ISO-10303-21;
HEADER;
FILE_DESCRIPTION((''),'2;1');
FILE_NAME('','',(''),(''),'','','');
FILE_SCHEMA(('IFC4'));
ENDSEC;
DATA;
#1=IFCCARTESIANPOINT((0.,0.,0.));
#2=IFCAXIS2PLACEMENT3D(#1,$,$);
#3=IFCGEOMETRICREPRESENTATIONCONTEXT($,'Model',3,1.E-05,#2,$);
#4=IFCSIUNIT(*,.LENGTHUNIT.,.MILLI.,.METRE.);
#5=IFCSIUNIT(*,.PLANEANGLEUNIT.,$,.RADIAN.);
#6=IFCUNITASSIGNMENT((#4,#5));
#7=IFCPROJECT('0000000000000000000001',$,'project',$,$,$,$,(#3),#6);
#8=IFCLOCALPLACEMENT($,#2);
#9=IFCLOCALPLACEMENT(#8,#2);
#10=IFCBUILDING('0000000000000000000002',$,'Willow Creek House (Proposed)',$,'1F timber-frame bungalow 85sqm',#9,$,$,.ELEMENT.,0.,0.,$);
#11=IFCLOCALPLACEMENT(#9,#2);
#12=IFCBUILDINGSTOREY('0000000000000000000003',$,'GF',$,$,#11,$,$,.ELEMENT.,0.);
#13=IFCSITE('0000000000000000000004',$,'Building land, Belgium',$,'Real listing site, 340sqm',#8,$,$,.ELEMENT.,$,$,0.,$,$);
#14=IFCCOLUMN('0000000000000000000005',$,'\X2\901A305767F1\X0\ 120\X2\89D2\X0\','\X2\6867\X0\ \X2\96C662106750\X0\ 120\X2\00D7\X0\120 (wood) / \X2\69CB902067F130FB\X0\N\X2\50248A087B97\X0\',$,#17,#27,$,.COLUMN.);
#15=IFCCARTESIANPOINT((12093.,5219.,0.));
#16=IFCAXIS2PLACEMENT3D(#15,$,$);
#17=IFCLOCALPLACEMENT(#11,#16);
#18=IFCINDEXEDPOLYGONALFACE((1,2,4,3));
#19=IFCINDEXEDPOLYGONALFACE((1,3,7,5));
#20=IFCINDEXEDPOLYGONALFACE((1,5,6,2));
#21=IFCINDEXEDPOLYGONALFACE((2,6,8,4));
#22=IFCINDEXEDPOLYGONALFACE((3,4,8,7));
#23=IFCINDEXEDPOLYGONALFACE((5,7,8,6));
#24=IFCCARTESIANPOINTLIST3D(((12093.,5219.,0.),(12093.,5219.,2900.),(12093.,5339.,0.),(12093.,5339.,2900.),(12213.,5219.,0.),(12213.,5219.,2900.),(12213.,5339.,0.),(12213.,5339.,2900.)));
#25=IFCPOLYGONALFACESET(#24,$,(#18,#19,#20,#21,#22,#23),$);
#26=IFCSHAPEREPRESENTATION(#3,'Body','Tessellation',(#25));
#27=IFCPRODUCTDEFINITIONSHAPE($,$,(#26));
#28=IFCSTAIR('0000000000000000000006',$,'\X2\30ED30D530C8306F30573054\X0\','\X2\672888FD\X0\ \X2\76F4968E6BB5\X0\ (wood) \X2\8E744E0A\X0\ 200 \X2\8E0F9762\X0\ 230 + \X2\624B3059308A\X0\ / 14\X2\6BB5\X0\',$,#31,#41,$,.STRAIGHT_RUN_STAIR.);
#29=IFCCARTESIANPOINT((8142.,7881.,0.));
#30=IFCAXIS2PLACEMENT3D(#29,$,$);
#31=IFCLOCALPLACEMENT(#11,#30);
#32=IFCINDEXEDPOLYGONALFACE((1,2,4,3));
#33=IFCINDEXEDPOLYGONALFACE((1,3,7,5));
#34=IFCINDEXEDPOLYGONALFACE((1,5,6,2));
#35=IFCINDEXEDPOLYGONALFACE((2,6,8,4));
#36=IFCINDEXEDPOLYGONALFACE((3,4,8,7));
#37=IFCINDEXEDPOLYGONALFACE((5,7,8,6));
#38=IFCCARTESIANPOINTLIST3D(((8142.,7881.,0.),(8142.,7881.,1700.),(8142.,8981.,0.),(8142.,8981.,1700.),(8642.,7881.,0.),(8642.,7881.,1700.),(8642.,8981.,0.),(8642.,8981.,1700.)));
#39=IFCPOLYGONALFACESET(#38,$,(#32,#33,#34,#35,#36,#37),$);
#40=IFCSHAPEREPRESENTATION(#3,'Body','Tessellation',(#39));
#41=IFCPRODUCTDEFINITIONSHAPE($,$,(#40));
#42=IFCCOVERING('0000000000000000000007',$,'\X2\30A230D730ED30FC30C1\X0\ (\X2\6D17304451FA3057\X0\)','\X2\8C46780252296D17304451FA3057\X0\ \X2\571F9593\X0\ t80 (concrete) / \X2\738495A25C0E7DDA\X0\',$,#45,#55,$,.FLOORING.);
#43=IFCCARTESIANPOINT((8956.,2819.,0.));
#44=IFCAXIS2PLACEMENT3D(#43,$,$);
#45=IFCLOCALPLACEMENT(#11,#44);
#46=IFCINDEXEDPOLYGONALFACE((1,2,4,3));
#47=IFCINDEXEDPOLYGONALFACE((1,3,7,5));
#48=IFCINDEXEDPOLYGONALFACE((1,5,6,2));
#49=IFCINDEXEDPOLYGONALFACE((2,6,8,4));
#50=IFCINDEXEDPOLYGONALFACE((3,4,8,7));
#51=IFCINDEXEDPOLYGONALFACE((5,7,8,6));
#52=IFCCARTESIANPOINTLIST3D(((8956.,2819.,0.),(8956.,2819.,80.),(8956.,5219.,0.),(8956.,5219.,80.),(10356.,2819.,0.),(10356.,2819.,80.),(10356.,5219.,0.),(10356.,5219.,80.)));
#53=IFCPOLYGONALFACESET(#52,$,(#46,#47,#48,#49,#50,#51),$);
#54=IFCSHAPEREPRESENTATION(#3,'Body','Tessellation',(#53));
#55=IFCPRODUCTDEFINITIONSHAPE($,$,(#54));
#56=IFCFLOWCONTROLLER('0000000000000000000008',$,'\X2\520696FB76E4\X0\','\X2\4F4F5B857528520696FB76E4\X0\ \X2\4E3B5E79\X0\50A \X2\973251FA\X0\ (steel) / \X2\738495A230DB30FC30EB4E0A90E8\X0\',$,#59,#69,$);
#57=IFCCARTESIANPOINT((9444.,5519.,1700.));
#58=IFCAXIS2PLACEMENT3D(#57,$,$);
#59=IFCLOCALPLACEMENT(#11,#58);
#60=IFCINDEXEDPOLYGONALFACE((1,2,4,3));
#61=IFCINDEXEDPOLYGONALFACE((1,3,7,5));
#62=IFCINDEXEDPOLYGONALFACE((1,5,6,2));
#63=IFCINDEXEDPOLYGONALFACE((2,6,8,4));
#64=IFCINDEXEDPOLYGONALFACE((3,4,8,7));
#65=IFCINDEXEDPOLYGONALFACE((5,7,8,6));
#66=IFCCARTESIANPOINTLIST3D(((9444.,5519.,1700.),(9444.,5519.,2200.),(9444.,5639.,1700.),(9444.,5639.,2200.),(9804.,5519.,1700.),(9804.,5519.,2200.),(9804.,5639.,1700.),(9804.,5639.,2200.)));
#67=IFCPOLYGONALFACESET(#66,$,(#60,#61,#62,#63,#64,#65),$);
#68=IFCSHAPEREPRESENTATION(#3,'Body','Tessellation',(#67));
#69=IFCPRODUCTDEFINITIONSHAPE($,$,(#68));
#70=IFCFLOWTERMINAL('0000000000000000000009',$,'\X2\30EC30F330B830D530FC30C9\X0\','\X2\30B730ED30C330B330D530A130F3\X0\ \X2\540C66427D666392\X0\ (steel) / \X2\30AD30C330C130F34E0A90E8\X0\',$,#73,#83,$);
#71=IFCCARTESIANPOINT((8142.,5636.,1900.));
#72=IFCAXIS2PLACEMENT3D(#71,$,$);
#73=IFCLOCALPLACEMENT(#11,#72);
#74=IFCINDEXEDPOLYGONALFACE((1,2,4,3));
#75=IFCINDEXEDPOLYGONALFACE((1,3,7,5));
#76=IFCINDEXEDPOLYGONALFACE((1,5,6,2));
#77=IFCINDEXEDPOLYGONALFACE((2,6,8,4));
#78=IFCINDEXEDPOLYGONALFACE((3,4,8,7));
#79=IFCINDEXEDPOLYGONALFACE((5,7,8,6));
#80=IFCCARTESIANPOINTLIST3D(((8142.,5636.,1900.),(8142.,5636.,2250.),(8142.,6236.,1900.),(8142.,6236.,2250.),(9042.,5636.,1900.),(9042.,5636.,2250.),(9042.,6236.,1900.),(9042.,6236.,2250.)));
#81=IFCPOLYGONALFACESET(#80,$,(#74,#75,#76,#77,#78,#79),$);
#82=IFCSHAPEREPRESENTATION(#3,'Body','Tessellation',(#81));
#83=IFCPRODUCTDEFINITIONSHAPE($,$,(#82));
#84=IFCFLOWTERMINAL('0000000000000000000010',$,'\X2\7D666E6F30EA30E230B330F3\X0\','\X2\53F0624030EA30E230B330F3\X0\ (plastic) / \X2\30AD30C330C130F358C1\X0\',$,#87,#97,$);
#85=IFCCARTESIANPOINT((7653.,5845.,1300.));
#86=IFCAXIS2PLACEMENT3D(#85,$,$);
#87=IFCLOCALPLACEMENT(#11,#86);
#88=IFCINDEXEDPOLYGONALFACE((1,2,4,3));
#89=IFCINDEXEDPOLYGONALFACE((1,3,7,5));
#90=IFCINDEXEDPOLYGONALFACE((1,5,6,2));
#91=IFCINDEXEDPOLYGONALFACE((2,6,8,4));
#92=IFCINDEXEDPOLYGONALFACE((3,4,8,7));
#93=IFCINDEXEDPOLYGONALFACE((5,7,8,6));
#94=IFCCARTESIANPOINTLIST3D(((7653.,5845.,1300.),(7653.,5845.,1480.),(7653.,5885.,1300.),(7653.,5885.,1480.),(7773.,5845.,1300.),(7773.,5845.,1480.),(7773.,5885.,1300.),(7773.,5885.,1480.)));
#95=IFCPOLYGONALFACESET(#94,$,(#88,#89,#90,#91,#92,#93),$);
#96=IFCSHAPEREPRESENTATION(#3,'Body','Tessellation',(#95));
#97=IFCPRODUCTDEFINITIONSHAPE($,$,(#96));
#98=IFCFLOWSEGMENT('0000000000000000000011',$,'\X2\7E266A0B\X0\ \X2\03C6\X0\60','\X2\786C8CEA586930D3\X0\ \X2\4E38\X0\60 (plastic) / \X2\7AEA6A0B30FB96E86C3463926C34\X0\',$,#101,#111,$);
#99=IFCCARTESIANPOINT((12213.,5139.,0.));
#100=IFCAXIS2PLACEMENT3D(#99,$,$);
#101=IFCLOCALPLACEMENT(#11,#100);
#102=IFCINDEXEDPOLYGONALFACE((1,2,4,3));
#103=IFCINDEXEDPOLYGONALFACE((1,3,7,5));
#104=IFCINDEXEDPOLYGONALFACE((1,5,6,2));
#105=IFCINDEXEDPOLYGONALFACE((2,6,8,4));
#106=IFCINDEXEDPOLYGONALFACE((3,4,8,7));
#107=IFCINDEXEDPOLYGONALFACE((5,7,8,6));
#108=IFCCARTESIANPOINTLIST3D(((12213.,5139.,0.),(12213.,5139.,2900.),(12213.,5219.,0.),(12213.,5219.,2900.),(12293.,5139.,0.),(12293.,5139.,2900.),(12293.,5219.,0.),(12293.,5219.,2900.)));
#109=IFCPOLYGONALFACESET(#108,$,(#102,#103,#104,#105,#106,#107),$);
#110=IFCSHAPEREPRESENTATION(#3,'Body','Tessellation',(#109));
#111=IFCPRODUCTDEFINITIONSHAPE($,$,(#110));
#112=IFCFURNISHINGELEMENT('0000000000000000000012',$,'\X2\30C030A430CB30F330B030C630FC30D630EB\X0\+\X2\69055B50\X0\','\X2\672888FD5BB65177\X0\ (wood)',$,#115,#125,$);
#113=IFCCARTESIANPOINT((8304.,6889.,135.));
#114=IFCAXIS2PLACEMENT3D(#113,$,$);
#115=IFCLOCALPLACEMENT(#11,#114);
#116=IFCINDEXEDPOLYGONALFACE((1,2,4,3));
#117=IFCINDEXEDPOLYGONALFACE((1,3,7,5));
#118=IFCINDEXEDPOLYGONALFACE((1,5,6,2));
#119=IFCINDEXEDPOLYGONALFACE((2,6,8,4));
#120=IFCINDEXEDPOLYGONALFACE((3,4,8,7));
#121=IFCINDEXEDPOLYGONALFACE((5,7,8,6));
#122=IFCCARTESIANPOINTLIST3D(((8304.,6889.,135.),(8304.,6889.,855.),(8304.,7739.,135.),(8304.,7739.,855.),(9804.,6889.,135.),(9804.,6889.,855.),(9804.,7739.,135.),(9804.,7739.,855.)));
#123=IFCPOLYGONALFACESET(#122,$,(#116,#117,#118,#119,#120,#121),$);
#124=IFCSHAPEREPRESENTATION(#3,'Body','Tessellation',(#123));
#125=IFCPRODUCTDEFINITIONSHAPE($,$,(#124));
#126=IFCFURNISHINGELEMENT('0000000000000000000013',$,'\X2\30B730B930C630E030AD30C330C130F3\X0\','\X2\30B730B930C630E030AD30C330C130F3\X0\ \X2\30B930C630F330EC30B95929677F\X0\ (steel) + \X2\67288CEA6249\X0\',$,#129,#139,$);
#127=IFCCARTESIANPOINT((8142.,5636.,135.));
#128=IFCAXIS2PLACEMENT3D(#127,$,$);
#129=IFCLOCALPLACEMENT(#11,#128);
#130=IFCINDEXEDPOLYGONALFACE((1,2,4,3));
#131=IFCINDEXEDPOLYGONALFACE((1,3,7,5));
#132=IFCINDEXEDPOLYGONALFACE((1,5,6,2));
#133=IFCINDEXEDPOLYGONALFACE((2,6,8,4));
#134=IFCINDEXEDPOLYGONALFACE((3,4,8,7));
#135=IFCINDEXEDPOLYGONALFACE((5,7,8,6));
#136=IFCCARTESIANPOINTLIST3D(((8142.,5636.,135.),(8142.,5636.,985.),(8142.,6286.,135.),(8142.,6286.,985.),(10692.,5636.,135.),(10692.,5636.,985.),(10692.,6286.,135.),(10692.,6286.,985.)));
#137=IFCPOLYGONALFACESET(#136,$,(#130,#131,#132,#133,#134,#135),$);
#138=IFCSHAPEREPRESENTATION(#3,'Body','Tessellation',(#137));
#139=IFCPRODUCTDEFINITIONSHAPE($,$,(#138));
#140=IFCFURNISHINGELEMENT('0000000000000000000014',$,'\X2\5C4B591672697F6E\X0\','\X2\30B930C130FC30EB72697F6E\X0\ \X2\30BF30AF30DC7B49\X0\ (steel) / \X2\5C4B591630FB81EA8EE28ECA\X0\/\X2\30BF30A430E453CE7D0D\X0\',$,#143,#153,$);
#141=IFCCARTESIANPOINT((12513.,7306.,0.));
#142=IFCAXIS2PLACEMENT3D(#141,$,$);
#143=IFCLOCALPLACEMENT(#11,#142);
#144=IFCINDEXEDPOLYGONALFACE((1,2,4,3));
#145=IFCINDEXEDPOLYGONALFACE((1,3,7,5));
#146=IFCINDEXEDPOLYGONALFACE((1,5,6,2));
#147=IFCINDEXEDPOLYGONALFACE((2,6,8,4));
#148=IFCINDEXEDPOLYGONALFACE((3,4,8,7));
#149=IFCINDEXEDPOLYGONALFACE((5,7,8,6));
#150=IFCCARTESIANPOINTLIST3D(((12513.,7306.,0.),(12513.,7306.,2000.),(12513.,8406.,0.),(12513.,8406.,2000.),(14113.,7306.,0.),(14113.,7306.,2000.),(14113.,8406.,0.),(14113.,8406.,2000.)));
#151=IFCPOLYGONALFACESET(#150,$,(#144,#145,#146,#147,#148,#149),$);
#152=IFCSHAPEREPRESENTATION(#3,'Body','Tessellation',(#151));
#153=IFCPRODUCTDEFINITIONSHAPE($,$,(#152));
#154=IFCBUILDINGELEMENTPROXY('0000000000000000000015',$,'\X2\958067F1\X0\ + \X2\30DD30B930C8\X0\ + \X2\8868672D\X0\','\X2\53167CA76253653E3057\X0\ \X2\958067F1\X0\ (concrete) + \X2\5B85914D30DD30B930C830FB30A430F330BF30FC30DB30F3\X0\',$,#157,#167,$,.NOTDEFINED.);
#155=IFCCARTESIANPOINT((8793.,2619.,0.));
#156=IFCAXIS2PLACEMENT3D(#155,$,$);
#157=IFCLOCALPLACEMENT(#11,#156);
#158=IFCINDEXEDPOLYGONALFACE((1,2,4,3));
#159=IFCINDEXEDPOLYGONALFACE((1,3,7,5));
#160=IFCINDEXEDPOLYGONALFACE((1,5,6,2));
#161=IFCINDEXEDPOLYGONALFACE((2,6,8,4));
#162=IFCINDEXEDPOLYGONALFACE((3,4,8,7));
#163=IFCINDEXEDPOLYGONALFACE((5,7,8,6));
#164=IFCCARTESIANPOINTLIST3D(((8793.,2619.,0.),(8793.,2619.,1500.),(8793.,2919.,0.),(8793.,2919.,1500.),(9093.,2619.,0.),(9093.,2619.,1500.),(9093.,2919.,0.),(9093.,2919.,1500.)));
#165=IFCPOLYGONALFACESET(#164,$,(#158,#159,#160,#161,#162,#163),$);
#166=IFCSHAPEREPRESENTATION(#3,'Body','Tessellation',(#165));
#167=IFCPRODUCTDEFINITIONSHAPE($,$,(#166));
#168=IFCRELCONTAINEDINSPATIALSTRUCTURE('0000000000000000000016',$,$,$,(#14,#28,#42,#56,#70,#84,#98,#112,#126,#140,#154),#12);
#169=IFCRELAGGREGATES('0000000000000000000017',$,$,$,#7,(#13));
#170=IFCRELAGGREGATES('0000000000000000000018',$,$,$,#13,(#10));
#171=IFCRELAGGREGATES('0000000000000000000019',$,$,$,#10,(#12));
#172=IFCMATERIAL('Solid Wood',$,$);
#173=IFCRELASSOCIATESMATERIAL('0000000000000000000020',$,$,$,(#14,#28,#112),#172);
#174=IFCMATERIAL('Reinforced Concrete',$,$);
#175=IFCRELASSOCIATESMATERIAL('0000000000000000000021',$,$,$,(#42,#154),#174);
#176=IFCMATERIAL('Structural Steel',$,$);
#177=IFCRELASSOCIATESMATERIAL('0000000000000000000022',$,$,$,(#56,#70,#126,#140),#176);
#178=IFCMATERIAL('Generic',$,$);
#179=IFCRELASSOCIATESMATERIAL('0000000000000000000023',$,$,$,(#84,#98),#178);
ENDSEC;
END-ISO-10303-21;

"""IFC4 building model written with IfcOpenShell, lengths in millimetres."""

from ifc_helpers import new_model, si_unit, frame, frame_2d, origin, place, context, project, spatial, rectangle, extrude, material, element, save


model = new_model("IFC4")

# Units and contexts
model_context = context("Model", 3, precision=1e-05, world=origin())
ifc_project = project(units=[si_unit("LENGTHUNIT", "METRE", prefix="MILLI"), si_unit("PLANEANGLEUNIT", "RADIAN")], contexts=[model_context])

# Site, building, storey
site_placement = place(None, origin())
site = spatial("IfcSite", under=ifc_project, at=site_placement, Name="Building land, Belgium", ObjectType="Real listing site, 340sqm", CompositionType="ELEMENT", RefElevation=0.0)
building_placement = place(site_placement, origin())
building = spatial("IfcBuilding", under=site, at=building_placement, Name="Willow Creek House (Proposed)", ObjectType="1F timber-frame bungalow 85sqm", CompositionType="ELEMENT", ElevationOfRefHeight=0.0, ElevationOfTerrain=0.0)
storey_placement = place(building_placement, origin())
storey = spatial("IfcBuildingStorey", under=building, at=storey_placement, Name="GF", CompositionType="ELEMENT", Elevation=0.0)

# Column
ifc_material_1 = material(Name="Solid Wood")
column_1_placement = place(storey_placement, frame((12093.0, 5219.0, 0.0)))
element("IfcColumn", 1, at=column_1_placement, inside=storey, material=ifc_material_1, Name="通し柱 120角", Description="桧 集成材 120×120 (wood) / 構造柱・N値計算", PredefinedType="COLUMN", context=model_context, shape_type="SweptSolid", body=[
    extrude(rectangle(XDim=120.0, YDim=120.0, at=frame_2d((60.0, 60.0))), frame((12093.0, 5219.0, 0.0)), (0.0, 0.0, 1.0), 2900.0),
])

# Stair
stair_placement = place(storey_placement, frame((8142.0, 7881.0, 0.0)))
element("IfcStair", 2, at=stair_placement, inside=storey, material=ifc_material_1, Name="ロフトはしご", Description="木製 直階段 (wood) 蹴上 200 踏面 230 + 手すり / 14段", PredefinedType="STRAIGHT_RUN_STAIR", context=model_context, shape_type="SweptSolid", body=[
    extrude(rectangle(XDim=500.0, YDim=1100.0, at=frame_2d((250.0, 550.0))), frame((8142.0, 7881.0, 0.0)), (0.0, 0.0, 1.0), 1700.0),
])

# Covering
ifc_material_2 = material(Name="Reinforced Concrete")
covering_placement = place(storey_placement, frame((8956.0, 2819.0, 0.0)))
element("IfcCovering", 3, at=covering_placement, inside=storey, material=ifc_material_2, Name="アプローチ (洗い出し)", Description="豆砂利洗い出し 土間 t80 (concrete) / 玄関導線", PredefinedType="FLOORING", context=model_context, shape_type="SweptSolid", body=[
    extrude(rectangle(XDim=1400.0, YDim=2400.0, at=frame_2d((700.0, 1200.0))), frame((8956.0, 2819.0, 0.0)), (0.0, 0.0, 1.0), 80.0),
])

# Flow controller
ifc_material_3 = material(Name="Structural Steel")
flow_controller_placement = place(storey_placement, frame((9444.0, 5519.0, 1700.0)))
element("IfcFlowController", 4, at=flow_controller_placement, inside=storey, material=ifc_material_3, Name="分電盤", Description="住宅用分電盤 主幹50A 露出 (steel) / 玄関ホール上部", context=model_context, shape_type="SweptSolid", body=[
    extrude(rectangle(XDim=360.0, YDim=120.0, at=frame_2d((180.0, 60.0))), frame((9444.0, 5519.0, 1700.0)), (0.0, 0.0, 1.0), 500.0),
])

# Flow terminals
flow_terminal_1_placement = place(storey_placement, frame((8142.0, 5636.0, 1900.0)))
element("IfcFlowTerminal", 5, at=flow_terminal_1_placement, inside=storey, material=ifc_material_3, Name="レンジフード", Description="シロッコファン 同時給排 (steel) / キッチン上部", context=model_context, shape_type="SweptSolid", body=[
    extrude(rectangle(XDim=900.0, YDim=600.0, at=frame_2d((450.0, 300.0))), frame((8142.0, 5636.0, 1900.0)), (0.0, 0.0, 1.0), 350.0),
])
ifc_material_4 = material(Name="Generic")
flow_terminal_2_placement = place(storey_placement, frame((7653.0, 5845.0, 1300.0)))
element("IfcFlowTerminal", 6, at=flow_terminal_2_placement, inside=storey, material=ifc_material_4, Name="給湯リモコン", Description="台所リモコン (plastic) / キッチン壁", context=model_context, shape_type="SweptSolid", body=[
    extrude(rectangle(XDim=120.0, YDim=40.0, at=frame_2d((60.0, 20.0))), frame((7653.0, 5845.0, 1300.0)), (0.0, 0.0, 1.0), 180.0),
])

# Flow segment
flow_segment_placement = place(storey_placement, frame((12213.0, 5139.0, 0.0)))
element("IfcFlowSegment", 7, at=flow_segment_placement, inside=storey, material=ifc_material_4, Name="縦樋 φ60", Description="硬質塩ビ 丸60 (plastic) / 竪樋・雨水排水", context=model_context, shape_type="SweptSolid", body=[
    extrude(rectangle(XDim=80.0, YDim=80.0, at=frame_2d((40.0, 40.0))), frame((12213.0, 5139.0, 0.0)), (0.0, 0.0, 1.0), 2900.0),
])

# Furnishing elements
furnishing_1_placement = place(storey_placement, frame((8304.0, 6889.0, 135.0)))
element("IfcFurnishingElement", 8, at=furnishing_1_placement, inside=storey, material=ifc_material_1, Name="ダイニングテーブル+椅子", Description="木製家具 (wood)", context=model_context, shape_type="SweptSolid", body=[
    extrude(rectangle(XDim=1500.0, YDim=850.0, at=frame_2d((750.0, 425.0))), frame((8304.0, 6889.0, 135.0)), (0.0, 0.0, 1.0), 720.0),
])
furnishing_2_placement = place(storey_placement, frame((8142.0, 5636.0, 135.0)))
element("IfcFurnishingElement", 9, at=furnishing_2_placement, inside=storey, material=ifc_material_3, Name="システムキッチン", Description="システムキッチン ステンレス天板 (steel) + 木質扉", context=model_context, shape_type="SweptSolid", body=[
    extrude(rectangle(XDim=2550.0, YDim=650.0, at=frame_2d((1275.0, 325.0))), frame((8142.0, 5636.0, 135.0)), (0.0, 0.0, 1.0), 850.0),
])
furnishing_3_placement = place(storey_placement, frame((12513.0, 7306.0, 0.0)))
element("IfcFurnishingElement", 10, at=furnishing_3_placement, inside=storey, material=ifc_material_3, Name="屋外物置", Description="スチール物置 タクボ等 (steel) / 屋外・自転車/タイヤ収納", context=model_context, shape_type="SweptSolid", body=[
    extrude(rectangle(XDim=1600.0, YDim=1100.0, at=frame_2d((800.0, 550.0))), frame((12513.0, 7306.0, 0.0)), (0.0, 0.0, 1.0), 2000.0),
])

# Building element proxy
proxy_placement = place(storey_placement, frame((8793.0, 2619.0, 0.0)))
element("IfcBuildingElementProxy", 11, at=proxy_placement, inside=storey, material=ifc_material_2, Name="門柱 + ポスト + 表札", Description="化粧打放し 門柱 (concrete) + 宅配ポスト・インターホン", PredefinedType="NOTDEFINED", context=model_context, shape_type="SweptSolid", body=[
    extrude(rectangle(XDim=300.0, YDim=300.0, at=frame_2d((150.0, 150.0))), frame((8793.0, 2619.0, 0.0)), (0.0, 0.0, 1.0), 1500.0),
])

save(model, "model.ifc")
